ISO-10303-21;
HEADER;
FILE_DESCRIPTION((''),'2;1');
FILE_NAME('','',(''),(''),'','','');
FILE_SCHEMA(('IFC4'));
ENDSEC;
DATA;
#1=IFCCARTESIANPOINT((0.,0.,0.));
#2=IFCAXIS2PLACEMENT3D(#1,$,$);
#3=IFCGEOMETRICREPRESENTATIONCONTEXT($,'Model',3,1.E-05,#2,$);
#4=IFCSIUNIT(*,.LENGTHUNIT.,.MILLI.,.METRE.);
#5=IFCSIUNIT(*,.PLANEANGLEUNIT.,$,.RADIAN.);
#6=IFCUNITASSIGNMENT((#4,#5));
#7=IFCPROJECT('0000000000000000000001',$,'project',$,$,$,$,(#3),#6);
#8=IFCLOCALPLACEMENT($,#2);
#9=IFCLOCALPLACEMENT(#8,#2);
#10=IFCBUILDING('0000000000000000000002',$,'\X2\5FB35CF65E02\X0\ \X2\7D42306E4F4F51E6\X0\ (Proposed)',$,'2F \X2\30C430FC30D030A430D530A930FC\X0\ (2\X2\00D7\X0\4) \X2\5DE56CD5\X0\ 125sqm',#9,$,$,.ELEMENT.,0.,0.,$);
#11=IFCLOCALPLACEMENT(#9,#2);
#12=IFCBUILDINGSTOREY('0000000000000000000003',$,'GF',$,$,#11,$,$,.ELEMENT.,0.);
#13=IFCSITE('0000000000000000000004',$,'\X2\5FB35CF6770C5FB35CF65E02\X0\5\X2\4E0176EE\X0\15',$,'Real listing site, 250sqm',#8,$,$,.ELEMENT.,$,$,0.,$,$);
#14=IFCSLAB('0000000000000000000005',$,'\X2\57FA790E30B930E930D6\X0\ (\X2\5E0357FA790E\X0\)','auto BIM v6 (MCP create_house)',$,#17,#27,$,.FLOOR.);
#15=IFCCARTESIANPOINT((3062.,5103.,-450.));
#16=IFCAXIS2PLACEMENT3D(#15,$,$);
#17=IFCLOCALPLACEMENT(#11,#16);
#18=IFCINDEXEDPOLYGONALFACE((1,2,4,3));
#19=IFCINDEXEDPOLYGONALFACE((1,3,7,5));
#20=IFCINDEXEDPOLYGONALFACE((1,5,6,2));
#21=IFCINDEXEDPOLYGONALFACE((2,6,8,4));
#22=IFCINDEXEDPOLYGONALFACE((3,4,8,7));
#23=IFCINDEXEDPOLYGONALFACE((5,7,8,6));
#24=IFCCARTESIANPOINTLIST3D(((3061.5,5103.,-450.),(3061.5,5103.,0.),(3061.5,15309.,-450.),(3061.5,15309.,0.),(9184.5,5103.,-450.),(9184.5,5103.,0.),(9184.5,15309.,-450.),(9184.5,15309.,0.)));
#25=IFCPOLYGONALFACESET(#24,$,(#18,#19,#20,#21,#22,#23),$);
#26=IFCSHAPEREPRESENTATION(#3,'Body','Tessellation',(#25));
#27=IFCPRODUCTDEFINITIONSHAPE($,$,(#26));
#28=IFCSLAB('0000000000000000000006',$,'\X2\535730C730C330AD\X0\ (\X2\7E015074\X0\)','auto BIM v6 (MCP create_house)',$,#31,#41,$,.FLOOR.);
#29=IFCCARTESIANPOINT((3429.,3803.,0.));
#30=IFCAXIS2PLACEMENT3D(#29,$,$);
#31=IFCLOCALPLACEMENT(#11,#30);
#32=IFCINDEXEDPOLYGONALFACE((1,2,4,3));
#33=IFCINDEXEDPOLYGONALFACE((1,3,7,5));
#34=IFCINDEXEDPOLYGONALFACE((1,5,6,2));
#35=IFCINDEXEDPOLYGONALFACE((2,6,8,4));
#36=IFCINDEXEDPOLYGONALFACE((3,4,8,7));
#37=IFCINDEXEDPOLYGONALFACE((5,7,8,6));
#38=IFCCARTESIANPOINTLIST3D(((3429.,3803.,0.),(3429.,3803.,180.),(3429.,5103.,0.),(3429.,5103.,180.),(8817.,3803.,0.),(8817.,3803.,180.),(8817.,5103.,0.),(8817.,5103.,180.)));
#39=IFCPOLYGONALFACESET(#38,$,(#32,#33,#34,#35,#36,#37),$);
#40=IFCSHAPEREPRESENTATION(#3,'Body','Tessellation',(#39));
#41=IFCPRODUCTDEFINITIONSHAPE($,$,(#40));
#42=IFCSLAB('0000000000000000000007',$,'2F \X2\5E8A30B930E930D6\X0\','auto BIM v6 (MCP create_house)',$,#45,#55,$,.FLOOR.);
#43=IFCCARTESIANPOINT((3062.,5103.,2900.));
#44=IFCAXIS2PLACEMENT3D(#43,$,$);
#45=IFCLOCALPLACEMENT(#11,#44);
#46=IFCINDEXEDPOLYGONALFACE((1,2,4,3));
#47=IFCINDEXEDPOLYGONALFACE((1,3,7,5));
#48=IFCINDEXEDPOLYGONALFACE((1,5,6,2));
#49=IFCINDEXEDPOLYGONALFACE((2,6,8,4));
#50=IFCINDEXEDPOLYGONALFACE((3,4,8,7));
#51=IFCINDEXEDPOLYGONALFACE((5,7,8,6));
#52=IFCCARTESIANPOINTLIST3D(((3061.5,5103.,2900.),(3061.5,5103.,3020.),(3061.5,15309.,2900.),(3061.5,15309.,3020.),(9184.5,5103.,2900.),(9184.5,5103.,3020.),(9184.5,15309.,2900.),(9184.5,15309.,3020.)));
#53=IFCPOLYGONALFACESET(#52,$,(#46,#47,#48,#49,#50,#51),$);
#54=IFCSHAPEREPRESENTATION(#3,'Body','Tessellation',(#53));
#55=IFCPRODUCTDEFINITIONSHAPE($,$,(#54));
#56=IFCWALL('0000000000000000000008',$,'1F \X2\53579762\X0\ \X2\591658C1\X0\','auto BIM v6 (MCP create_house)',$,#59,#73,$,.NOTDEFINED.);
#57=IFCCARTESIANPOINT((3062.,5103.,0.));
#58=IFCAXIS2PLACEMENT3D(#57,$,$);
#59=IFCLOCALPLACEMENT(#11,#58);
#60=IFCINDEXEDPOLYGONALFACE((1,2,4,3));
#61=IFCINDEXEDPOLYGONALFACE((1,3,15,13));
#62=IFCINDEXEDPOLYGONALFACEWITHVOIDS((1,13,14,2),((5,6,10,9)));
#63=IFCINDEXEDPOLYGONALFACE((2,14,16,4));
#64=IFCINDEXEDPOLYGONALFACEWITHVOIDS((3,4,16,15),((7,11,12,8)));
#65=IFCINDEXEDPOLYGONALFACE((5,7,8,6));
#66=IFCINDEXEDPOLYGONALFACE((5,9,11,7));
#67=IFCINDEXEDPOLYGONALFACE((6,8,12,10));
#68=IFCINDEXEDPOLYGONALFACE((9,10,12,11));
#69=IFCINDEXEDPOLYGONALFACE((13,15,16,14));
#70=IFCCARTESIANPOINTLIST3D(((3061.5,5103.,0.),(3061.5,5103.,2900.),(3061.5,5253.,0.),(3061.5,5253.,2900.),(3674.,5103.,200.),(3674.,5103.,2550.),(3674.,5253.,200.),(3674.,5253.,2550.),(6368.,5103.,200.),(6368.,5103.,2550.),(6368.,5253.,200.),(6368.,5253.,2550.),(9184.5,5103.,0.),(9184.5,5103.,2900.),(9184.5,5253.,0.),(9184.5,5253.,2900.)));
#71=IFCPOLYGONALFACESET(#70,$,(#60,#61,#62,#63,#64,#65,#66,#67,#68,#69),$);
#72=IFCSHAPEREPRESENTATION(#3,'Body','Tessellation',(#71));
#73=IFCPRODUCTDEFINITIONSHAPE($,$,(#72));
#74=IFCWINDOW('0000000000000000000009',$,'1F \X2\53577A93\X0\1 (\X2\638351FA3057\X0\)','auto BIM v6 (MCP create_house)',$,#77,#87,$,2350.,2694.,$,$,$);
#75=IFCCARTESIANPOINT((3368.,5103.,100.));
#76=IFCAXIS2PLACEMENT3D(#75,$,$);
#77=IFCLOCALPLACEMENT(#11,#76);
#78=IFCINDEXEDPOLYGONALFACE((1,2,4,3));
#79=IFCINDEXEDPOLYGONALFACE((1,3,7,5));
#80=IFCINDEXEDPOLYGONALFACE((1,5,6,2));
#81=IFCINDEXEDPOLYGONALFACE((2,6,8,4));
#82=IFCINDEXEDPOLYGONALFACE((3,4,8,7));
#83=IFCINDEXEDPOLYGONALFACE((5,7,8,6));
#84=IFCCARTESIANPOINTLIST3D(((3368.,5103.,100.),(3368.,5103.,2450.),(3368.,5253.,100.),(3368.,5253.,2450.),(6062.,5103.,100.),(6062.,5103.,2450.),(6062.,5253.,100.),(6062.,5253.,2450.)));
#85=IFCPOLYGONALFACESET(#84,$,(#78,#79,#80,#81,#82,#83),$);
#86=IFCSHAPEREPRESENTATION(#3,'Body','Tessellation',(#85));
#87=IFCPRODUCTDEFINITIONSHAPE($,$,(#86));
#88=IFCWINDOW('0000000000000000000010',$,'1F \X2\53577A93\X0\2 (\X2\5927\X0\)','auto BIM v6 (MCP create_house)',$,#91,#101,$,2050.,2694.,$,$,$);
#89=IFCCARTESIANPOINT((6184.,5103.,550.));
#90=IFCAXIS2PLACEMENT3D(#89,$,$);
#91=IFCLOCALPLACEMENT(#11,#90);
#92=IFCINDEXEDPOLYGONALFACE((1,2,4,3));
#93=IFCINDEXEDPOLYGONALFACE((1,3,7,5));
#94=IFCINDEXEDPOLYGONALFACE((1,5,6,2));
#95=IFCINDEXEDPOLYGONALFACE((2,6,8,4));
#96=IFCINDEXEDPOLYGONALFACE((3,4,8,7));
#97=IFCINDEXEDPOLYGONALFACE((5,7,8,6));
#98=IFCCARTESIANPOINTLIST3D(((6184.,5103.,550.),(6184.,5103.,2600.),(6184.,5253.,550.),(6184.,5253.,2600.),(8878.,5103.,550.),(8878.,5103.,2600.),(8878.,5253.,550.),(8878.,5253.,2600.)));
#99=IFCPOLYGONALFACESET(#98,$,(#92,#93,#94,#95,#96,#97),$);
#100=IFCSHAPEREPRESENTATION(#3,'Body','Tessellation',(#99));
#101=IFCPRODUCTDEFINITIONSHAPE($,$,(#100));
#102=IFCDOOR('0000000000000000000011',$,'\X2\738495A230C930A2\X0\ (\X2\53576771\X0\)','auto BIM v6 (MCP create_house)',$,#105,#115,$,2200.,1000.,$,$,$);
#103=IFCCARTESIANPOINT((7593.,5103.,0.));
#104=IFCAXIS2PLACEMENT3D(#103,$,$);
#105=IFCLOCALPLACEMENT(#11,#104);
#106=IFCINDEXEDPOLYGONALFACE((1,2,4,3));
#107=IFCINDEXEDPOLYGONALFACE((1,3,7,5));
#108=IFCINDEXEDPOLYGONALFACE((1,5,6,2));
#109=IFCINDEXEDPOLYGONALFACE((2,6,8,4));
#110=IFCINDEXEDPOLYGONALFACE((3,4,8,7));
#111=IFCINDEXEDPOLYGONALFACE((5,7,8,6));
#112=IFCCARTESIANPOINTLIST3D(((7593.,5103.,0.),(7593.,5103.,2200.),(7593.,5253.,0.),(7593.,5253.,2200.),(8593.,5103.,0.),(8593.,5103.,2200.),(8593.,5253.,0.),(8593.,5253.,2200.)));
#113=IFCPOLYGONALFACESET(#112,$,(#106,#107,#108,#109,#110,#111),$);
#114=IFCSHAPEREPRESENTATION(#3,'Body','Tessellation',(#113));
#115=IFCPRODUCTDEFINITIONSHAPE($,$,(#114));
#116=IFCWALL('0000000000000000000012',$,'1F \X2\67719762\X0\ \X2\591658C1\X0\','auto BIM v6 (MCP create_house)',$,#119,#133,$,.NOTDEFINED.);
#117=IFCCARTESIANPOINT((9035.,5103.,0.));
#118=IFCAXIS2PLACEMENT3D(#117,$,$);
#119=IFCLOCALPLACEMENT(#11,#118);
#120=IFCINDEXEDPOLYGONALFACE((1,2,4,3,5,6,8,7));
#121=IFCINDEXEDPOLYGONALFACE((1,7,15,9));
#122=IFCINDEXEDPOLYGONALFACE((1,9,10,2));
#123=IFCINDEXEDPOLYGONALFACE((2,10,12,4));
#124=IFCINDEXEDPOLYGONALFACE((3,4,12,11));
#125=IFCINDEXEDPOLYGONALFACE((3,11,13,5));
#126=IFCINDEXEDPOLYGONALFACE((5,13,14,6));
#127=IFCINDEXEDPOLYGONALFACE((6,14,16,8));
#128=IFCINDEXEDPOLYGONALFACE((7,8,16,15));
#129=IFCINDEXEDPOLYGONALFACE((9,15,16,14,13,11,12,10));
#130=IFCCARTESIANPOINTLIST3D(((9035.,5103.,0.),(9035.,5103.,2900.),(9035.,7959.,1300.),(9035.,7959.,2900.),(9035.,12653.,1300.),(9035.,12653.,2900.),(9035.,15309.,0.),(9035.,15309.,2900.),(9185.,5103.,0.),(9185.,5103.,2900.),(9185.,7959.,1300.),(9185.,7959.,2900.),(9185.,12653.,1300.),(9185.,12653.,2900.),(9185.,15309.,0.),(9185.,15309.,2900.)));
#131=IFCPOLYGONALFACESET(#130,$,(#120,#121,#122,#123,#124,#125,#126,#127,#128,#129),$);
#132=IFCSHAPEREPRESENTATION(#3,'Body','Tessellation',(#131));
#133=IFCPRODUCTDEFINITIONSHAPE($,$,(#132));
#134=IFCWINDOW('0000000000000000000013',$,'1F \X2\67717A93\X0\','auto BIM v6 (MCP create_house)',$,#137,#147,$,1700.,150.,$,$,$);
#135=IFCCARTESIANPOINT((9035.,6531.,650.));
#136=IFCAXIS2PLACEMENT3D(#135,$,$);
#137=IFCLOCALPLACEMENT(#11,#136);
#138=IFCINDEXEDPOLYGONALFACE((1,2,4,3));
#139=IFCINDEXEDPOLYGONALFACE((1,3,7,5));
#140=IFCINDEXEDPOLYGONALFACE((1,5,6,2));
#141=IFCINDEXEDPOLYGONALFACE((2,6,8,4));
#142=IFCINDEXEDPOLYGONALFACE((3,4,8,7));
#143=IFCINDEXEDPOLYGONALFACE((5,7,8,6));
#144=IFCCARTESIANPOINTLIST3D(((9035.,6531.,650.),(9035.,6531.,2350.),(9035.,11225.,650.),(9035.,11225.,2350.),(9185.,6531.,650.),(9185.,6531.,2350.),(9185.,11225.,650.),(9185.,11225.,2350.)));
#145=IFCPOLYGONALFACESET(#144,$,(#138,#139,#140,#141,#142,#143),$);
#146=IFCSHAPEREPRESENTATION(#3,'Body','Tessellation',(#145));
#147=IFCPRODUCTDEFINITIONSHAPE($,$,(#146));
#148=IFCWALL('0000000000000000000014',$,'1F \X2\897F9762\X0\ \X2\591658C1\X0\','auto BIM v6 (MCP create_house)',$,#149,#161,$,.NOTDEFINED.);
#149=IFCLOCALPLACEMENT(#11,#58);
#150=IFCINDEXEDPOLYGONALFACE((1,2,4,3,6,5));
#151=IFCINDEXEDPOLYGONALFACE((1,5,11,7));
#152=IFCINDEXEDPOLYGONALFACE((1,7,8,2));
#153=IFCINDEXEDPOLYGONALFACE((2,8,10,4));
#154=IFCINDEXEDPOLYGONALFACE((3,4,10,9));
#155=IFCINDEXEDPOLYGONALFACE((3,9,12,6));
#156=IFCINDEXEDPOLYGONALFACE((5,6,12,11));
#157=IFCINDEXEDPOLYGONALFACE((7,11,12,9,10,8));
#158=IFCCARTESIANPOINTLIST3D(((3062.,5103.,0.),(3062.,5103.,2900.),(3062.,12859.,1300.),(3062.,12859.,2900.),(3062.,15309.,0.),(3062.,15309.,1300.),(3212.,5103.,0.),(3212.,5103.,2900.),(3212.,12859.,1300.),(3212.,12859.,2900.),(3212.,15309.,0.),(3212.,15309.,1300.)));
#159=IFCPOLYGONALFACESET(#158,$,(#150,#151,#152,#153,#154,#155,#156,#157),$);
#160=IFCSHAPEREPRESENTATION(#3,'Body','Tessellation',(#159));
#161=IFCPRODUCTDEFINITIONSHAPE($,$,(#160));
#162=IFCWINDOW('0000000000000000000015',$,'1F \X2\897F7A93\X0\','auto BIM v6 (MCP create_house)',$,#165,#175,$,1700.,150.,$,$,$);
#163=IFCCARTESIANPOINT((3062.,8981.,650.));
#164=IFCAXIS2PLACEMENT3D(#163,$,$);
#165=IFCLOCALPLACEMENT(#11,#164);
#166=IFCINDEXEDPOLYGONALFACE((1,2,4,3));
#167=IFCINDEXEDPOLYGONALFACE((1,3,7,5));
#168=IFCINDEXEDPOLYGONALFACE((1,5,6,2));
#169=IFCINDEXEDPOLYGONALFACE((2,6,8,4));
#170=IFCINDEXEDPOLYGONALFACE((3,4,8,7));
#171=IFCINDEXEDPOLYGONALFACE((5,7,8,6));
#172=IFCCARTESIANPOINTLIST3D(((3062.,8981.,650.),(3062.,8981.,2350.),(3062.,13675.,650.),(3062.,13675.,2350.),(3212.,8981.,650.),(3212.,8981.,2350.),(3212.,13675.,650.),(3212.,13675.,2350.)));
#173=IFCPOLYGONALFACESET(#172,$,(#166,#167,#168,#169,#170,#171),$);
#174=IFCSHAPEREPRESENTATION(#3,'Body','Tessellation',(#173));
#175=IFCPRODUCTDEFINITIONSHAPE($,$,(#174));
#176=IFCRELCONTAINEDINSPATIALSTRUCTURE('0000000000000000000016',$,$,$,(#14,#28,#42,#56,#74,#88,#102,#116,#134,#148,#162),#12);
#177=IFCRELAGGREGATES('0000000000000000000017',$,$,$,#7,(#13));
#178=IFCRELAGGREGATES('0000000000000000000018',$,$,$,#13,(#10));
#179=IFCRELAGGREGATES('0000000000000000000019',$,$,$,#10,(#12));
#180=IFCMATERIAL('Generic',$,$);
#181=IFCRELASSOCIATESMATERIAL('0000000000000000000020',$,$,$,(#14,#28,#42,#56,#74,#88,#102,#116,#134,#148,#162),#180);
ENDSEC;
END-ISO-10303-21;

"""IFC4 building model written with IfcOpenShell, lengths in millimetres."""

from ifc_helpers import new_model, si_unit, frame, frame_2d, origin, place, context, project, spatial, rectangle, extrude, material, element, fill, save


model = new_model("IFC4")

# Units and contexts
model_context = context("Model", 3, precision=1e-05, world=origin())
ifc_project = project(units=[si_unit("LENGTHUNIT", "METRE", prefix="MILLI"), si_unit("PLANEANGLEUNIT", "RADIAN")], contexts=[model_context])

# Site, building, storey
site_placement = place(None, origin())
site = spatial("IfcSite", under=ifc_project, at=site_placement, Name="徳島県徳島市5丁目15", ObjectType="Real listing site, 250sqm", CompositionType="ELEMENT", RefElevation=0.0)
building_placement = place(site_placement, origin())
building = spatial("IfcBuilding", under=site, at=building_placement, Name="徳島市 終の住処 (Proposed)", ObjectType="2F ツーバイフォー (2×4) 工法 125sqm", CompositionType="ELEMENT", ElevationOfRefHeight=0.0, ElevationOfTerrain=0.0)
storey_placement = place(building_placement, origin())
storey = spatial("IfcBuildingStorey", under=building, at=storey_placement, Name="GF", CompositionType="ELEMENT", Elevation=0.0)

# Slabs
ifc_material = material(Name="Generic")
slab_1_placement = place(storey_placement, frame((3062.0, 5103.0, -450.0)))
element("IfcSlab", 1, at=slab_1_placement, inside=storey, material=ifc_material, Name="基礎スラブ (布基礎)", Description="auto BIM v6 (MCP create_house)", PredefinedType="FLOOR", context=model_context, shape_type="SweptSolid", body=[
    extrude(rectangle(XDim=6123.0, YDim=10206.0, at=frame_2d((3061.0, 5103.0))), frame((3062.0, 5103.0, -450.0)), (0.0, 0.0, 1.0), 450.0),
])
slab_2_placement = place(storey_placement, frame((3429.0, 3803.0, 0.0)))
element("IfcSlab", 2, at=slab_2_placement, inside=storey, material=ifc_material, Name="南デッキ (縁側)", Description="auto BIM v6 (MCP create_house)", PredefinedType="FLOOR", context=model_context, shape_type="SweptSolid", body=[
    extrude(rectangle(XDim=5388.0, YDim=1300.0, at=frame_2d((2694.0, 650.0))), frame((3429.0, 3803.0, 0.0)), (0.0, 0.0, 1.0), 180.0),
])
slab_3_placement = place(storey_placement, frame((3062.0, 5103.0, 2900.0)))
element("IfcSlab", 3, at=slab_3_placement, inside=storey, material=ifc_material, Name="2F 床スラブ", Description="auto BIM v6 (MCP create_house)", PredefinedType="FLOOR", context=model_context, shape_type="SweptSolid", body=[
    extrude(rectangle(XDim=6123.0, YDim=10206.0, at=frame_2d((3061.0, 5103.0))), frame((3062.0, 5103.0, 2900.0)), (0.0, 0.0, 1.0), 120.0),
])

# Wall, openings, windows, door
wall_1_placement = place(storey_placement, frame((3062.0, 5103.0, 0.0)))
wall_1 = element("IfcWall", 4, at=wall_1_placement, inside=storey, material=ifc_material, Name="1F 南面 外壁", Description="auto BIM v6 (MCP create_house)", PredefinedType="NOTDEFINED", context=model_context, shape_type="SweptSolid", body=[
    extrude(rectangle(XDim=6123.0, YDim=150.0, at=frame_2d((3061.0, 75.0))), frame((3062.0, 5103.0, 0.0)), (0.0, 0.0, 1.0), 2900.0),
])
opening_1_placement = place(storey_placement, frame((3368.0, 5103.0, 100.0)))
opening_1 = element("IfcOpeningElement", 5, at=opening_1_placement, cuts=wall_1, PredefinedType="NOTDEFINED", context=model_context, shape_type="SweptSolid", body=[
    extrude(rectangle(XDim=2694.0, YDim=150.0, at=frame_2d((1347.0, 75.0))), frame((3368.0, 5103.0, 100.0)), (0.0, 0.0, 1.0), 2350.0),
])
opening_2_placement = place(storey_placement, frame((6184.0, 5103.0, 550.0)))
opening_2 = element("IfcOpeningElement", 6, at=opening_2_placement, cuts=wall_1, PredefinedType="NOTDEFINED", context=model_context, shape_type="SweptSolid", body=[
    extrude(rectangle(XDim=2694.0, YDim=150.0, at=frame_2d((1347.0, 75.0))), frame((6184.0, 5103.0, 550.0)), (0.0, 0.0, 1.0), 2050.0),
])
opening_3_placement = place(storey_placement, frame((7593.0, 5103.0, 0.0)))
opening_3 = element("IfcOpeningElement", 7, at=opening_3_placement, cuts=wall_1, PredefinedType="NOTDEFINED", context=model_context, shape_type="SweptSolid", body=[
    extrude(rectangle(XDim=1000.0, YDim=150.0, at=frame_2d((500.0, 75.0))), frame((7593.0, 5103.0, 0.0)), (0.0, 0.0, 1.0), 2200.0),
])
window_1_placement = place(storey_placement, frame((3368.0, 5103.0, 100.0)))
window_1 = element("IfcWindow", 8, at=window_1_placement, inside=storey, material=ifc_material, Name="1F 南窓1 (掃出し)", Description="auto BIM v6 (MCP create_house)", OverallHeight=2350.0, OverallWidth=2694.0, context=model_context, shape_type="SweptSolid", body=[
    extrude(rectangle(XDim=2694.0, YDim=150.0, at=frame_2d((1347.0, 75.0))), frame((3368.0, 5103.0, 100.0)), (0.0, 0.0, 1.0), 2350.0),
])
fill(opening_1, window_1)
window_2_placement = place(storey_placement, frame((6184.0, 5103.0, 550.0)))
window_2 = element("IfcWindow", 9, at=window_2_placement, inside=storey, material=ifc_material, Name="1F 南窓2 (大)", Description="auto BIM v6 (MCP create_house)", OverallHeight=2050.0, OverallWidth=2694.0, context=model_context, shape_type="SweptSolid", body=[
    extrude(rectangle(XDim=2694.0, YDim=150.0, at=frame_2d((1347.0, 75.0))), frame((6184.0, 5103.0, 550.0)), (0.0, 0.0, 1.0), 2050.0),
])
fill(opening_2, window_2)
door_placement = place(storey_placement, frame((7593.0, 5103.0, 0.0)))
door = element("IfcDoor", 10, at=door_placement, inside=storey, material=ifc_material, Name="玄関ドア (南東)", Description="auto BIM v6 (MCP create_house)", OverallHeight=2200.0, OverallWidth=1000.0, context=model_context, shape_type="SweptSolid", body=[
    extrude(rectangle(XDim=1000.0, YDim=150.0, at=frame_2d((500.0, 75.0))), frame((7593.0, 5103.0, 0.0)), (0.0, 0.0, 1.0), 2200.0),
])
fill(opening_3, door)

# Walls, openings, windows
wall_2_placement = place(storey_placement, frame((9035.0, 5103.0, 0.0)))
wall_2 = element("IfcWall", 11, at=wall_2_placement, inside=storey, material=ifc_material, Name="1F 東面 外壁", Description="auto BIM v6 (MCP create_house)", PredefinedType="NOTDEFINED", context=model_context, shape_type="SweptSolid", body=[
    extrude(rectangle(XDim=150.0, YDim=10206.0, at=frame_2d((75.0, 5103.0))), frame((9035.0, 5103.0, 0.0)), (0.0, 0.0, 1.0), 2900.0),
])
opening_4_placement = place(storey_placement, frame((9035.0, 6531.0, 650.0)))
opening_4 = element("IfcOpeningElement", 12, at=opening_4_placement, cuts=wall_2, PredefinedType="NOTDEFINED", context=model_context, shape_type="SweptSolid", body=[
    extrude(rectangle(XDim=150.0, YDim=4694.0, at=frame_2d((75.0, 2347.0))), frame((9035.0, 6531.0, 650.0)), (0.0, 0.0, 1.0), 1700.0),
])
window_3_placement = place(storey_placement, frame((9035.0, 6531.0, 650.0)))
window_3 = element("IfcWindow", 13, at=window_3_placement, inside=storey, material=ifc_material, Name="1F 東窓", Description="auto BIM v6 (MCP create_house)", OverallHeight=1700.0, OverallWidth=150.0, context=model_context, shape_type="SweptSolid", body=[
    extrude(rectangle(XDim=150.0, YDim=4694.0, at=frame_2d((75.0, 2347.0))), frame((9035.0, 6531.0, 650.0)), (0.0, 0.0, 1.0), 1700.0),
])
fill(opening_4, window_3)
wall_3_placement = place(storey_placement, frame((3062.0, 5103.0, 0.0)))
wall_3 = element("IfcWall", 14, at=wall_3_placement, inside=storey, material=ifc_material, Name="1F 西面 外壁", Description="auto BIM v6 (MCP create_house)", PredefinedType="NOTDEFINED", context=model_context, shape_type="SweptSolid", body=[
    extrude(rectangle(XDim=150.0, YDim=10206.0, at=frame_2d((75.0, 5103.0))), frame((3062.0, 5103.0, 0.0)), (0.0, 0.0, 1.0), 2900.0),
])
opening_5_placement = place(storey_placement, frame((3062.0, 8981.0, 650.0)))
opening_5 = element("IfcOpeningElement", 15, at=opening_5_placement, cuts=wall_3, PredefinedType="NOTDEFINED", context=model_context, shape_type="SweptSolid", body=[
    extrude(rectangle(XDim=150.0, YDim=4694.0, at=frame_2d((75.0, 2347.0))), frame((3062.0, 8981.0, 650.0)), (0.0, 0.0, 1.0), 1700.0),
])
window_4_placement = place(storey_placement, frame((3062.0, 8981.0, 650.0)))
window_4 = element("IfcWindow", 16, at=window_4_placement, inside=storey, material=ifc_material, Name="1F 西窓", Description="auto BIM v6 (MCP create_house)", OverallHeight=1700.0, OverallWidth=150.0, context=model_context, shape_type="SweptSolid", body=[
    extrude(rectangle(XDim=150.0, YDim=4694.0, at=frame_2d((75.0, 2347.0))), frame((3062.0, 8981.0, 650.0)), (0.0, 0.0, 1.0), 1700.0),
])
fill(opening_5, window_4)

save(model, "model.ifc")
